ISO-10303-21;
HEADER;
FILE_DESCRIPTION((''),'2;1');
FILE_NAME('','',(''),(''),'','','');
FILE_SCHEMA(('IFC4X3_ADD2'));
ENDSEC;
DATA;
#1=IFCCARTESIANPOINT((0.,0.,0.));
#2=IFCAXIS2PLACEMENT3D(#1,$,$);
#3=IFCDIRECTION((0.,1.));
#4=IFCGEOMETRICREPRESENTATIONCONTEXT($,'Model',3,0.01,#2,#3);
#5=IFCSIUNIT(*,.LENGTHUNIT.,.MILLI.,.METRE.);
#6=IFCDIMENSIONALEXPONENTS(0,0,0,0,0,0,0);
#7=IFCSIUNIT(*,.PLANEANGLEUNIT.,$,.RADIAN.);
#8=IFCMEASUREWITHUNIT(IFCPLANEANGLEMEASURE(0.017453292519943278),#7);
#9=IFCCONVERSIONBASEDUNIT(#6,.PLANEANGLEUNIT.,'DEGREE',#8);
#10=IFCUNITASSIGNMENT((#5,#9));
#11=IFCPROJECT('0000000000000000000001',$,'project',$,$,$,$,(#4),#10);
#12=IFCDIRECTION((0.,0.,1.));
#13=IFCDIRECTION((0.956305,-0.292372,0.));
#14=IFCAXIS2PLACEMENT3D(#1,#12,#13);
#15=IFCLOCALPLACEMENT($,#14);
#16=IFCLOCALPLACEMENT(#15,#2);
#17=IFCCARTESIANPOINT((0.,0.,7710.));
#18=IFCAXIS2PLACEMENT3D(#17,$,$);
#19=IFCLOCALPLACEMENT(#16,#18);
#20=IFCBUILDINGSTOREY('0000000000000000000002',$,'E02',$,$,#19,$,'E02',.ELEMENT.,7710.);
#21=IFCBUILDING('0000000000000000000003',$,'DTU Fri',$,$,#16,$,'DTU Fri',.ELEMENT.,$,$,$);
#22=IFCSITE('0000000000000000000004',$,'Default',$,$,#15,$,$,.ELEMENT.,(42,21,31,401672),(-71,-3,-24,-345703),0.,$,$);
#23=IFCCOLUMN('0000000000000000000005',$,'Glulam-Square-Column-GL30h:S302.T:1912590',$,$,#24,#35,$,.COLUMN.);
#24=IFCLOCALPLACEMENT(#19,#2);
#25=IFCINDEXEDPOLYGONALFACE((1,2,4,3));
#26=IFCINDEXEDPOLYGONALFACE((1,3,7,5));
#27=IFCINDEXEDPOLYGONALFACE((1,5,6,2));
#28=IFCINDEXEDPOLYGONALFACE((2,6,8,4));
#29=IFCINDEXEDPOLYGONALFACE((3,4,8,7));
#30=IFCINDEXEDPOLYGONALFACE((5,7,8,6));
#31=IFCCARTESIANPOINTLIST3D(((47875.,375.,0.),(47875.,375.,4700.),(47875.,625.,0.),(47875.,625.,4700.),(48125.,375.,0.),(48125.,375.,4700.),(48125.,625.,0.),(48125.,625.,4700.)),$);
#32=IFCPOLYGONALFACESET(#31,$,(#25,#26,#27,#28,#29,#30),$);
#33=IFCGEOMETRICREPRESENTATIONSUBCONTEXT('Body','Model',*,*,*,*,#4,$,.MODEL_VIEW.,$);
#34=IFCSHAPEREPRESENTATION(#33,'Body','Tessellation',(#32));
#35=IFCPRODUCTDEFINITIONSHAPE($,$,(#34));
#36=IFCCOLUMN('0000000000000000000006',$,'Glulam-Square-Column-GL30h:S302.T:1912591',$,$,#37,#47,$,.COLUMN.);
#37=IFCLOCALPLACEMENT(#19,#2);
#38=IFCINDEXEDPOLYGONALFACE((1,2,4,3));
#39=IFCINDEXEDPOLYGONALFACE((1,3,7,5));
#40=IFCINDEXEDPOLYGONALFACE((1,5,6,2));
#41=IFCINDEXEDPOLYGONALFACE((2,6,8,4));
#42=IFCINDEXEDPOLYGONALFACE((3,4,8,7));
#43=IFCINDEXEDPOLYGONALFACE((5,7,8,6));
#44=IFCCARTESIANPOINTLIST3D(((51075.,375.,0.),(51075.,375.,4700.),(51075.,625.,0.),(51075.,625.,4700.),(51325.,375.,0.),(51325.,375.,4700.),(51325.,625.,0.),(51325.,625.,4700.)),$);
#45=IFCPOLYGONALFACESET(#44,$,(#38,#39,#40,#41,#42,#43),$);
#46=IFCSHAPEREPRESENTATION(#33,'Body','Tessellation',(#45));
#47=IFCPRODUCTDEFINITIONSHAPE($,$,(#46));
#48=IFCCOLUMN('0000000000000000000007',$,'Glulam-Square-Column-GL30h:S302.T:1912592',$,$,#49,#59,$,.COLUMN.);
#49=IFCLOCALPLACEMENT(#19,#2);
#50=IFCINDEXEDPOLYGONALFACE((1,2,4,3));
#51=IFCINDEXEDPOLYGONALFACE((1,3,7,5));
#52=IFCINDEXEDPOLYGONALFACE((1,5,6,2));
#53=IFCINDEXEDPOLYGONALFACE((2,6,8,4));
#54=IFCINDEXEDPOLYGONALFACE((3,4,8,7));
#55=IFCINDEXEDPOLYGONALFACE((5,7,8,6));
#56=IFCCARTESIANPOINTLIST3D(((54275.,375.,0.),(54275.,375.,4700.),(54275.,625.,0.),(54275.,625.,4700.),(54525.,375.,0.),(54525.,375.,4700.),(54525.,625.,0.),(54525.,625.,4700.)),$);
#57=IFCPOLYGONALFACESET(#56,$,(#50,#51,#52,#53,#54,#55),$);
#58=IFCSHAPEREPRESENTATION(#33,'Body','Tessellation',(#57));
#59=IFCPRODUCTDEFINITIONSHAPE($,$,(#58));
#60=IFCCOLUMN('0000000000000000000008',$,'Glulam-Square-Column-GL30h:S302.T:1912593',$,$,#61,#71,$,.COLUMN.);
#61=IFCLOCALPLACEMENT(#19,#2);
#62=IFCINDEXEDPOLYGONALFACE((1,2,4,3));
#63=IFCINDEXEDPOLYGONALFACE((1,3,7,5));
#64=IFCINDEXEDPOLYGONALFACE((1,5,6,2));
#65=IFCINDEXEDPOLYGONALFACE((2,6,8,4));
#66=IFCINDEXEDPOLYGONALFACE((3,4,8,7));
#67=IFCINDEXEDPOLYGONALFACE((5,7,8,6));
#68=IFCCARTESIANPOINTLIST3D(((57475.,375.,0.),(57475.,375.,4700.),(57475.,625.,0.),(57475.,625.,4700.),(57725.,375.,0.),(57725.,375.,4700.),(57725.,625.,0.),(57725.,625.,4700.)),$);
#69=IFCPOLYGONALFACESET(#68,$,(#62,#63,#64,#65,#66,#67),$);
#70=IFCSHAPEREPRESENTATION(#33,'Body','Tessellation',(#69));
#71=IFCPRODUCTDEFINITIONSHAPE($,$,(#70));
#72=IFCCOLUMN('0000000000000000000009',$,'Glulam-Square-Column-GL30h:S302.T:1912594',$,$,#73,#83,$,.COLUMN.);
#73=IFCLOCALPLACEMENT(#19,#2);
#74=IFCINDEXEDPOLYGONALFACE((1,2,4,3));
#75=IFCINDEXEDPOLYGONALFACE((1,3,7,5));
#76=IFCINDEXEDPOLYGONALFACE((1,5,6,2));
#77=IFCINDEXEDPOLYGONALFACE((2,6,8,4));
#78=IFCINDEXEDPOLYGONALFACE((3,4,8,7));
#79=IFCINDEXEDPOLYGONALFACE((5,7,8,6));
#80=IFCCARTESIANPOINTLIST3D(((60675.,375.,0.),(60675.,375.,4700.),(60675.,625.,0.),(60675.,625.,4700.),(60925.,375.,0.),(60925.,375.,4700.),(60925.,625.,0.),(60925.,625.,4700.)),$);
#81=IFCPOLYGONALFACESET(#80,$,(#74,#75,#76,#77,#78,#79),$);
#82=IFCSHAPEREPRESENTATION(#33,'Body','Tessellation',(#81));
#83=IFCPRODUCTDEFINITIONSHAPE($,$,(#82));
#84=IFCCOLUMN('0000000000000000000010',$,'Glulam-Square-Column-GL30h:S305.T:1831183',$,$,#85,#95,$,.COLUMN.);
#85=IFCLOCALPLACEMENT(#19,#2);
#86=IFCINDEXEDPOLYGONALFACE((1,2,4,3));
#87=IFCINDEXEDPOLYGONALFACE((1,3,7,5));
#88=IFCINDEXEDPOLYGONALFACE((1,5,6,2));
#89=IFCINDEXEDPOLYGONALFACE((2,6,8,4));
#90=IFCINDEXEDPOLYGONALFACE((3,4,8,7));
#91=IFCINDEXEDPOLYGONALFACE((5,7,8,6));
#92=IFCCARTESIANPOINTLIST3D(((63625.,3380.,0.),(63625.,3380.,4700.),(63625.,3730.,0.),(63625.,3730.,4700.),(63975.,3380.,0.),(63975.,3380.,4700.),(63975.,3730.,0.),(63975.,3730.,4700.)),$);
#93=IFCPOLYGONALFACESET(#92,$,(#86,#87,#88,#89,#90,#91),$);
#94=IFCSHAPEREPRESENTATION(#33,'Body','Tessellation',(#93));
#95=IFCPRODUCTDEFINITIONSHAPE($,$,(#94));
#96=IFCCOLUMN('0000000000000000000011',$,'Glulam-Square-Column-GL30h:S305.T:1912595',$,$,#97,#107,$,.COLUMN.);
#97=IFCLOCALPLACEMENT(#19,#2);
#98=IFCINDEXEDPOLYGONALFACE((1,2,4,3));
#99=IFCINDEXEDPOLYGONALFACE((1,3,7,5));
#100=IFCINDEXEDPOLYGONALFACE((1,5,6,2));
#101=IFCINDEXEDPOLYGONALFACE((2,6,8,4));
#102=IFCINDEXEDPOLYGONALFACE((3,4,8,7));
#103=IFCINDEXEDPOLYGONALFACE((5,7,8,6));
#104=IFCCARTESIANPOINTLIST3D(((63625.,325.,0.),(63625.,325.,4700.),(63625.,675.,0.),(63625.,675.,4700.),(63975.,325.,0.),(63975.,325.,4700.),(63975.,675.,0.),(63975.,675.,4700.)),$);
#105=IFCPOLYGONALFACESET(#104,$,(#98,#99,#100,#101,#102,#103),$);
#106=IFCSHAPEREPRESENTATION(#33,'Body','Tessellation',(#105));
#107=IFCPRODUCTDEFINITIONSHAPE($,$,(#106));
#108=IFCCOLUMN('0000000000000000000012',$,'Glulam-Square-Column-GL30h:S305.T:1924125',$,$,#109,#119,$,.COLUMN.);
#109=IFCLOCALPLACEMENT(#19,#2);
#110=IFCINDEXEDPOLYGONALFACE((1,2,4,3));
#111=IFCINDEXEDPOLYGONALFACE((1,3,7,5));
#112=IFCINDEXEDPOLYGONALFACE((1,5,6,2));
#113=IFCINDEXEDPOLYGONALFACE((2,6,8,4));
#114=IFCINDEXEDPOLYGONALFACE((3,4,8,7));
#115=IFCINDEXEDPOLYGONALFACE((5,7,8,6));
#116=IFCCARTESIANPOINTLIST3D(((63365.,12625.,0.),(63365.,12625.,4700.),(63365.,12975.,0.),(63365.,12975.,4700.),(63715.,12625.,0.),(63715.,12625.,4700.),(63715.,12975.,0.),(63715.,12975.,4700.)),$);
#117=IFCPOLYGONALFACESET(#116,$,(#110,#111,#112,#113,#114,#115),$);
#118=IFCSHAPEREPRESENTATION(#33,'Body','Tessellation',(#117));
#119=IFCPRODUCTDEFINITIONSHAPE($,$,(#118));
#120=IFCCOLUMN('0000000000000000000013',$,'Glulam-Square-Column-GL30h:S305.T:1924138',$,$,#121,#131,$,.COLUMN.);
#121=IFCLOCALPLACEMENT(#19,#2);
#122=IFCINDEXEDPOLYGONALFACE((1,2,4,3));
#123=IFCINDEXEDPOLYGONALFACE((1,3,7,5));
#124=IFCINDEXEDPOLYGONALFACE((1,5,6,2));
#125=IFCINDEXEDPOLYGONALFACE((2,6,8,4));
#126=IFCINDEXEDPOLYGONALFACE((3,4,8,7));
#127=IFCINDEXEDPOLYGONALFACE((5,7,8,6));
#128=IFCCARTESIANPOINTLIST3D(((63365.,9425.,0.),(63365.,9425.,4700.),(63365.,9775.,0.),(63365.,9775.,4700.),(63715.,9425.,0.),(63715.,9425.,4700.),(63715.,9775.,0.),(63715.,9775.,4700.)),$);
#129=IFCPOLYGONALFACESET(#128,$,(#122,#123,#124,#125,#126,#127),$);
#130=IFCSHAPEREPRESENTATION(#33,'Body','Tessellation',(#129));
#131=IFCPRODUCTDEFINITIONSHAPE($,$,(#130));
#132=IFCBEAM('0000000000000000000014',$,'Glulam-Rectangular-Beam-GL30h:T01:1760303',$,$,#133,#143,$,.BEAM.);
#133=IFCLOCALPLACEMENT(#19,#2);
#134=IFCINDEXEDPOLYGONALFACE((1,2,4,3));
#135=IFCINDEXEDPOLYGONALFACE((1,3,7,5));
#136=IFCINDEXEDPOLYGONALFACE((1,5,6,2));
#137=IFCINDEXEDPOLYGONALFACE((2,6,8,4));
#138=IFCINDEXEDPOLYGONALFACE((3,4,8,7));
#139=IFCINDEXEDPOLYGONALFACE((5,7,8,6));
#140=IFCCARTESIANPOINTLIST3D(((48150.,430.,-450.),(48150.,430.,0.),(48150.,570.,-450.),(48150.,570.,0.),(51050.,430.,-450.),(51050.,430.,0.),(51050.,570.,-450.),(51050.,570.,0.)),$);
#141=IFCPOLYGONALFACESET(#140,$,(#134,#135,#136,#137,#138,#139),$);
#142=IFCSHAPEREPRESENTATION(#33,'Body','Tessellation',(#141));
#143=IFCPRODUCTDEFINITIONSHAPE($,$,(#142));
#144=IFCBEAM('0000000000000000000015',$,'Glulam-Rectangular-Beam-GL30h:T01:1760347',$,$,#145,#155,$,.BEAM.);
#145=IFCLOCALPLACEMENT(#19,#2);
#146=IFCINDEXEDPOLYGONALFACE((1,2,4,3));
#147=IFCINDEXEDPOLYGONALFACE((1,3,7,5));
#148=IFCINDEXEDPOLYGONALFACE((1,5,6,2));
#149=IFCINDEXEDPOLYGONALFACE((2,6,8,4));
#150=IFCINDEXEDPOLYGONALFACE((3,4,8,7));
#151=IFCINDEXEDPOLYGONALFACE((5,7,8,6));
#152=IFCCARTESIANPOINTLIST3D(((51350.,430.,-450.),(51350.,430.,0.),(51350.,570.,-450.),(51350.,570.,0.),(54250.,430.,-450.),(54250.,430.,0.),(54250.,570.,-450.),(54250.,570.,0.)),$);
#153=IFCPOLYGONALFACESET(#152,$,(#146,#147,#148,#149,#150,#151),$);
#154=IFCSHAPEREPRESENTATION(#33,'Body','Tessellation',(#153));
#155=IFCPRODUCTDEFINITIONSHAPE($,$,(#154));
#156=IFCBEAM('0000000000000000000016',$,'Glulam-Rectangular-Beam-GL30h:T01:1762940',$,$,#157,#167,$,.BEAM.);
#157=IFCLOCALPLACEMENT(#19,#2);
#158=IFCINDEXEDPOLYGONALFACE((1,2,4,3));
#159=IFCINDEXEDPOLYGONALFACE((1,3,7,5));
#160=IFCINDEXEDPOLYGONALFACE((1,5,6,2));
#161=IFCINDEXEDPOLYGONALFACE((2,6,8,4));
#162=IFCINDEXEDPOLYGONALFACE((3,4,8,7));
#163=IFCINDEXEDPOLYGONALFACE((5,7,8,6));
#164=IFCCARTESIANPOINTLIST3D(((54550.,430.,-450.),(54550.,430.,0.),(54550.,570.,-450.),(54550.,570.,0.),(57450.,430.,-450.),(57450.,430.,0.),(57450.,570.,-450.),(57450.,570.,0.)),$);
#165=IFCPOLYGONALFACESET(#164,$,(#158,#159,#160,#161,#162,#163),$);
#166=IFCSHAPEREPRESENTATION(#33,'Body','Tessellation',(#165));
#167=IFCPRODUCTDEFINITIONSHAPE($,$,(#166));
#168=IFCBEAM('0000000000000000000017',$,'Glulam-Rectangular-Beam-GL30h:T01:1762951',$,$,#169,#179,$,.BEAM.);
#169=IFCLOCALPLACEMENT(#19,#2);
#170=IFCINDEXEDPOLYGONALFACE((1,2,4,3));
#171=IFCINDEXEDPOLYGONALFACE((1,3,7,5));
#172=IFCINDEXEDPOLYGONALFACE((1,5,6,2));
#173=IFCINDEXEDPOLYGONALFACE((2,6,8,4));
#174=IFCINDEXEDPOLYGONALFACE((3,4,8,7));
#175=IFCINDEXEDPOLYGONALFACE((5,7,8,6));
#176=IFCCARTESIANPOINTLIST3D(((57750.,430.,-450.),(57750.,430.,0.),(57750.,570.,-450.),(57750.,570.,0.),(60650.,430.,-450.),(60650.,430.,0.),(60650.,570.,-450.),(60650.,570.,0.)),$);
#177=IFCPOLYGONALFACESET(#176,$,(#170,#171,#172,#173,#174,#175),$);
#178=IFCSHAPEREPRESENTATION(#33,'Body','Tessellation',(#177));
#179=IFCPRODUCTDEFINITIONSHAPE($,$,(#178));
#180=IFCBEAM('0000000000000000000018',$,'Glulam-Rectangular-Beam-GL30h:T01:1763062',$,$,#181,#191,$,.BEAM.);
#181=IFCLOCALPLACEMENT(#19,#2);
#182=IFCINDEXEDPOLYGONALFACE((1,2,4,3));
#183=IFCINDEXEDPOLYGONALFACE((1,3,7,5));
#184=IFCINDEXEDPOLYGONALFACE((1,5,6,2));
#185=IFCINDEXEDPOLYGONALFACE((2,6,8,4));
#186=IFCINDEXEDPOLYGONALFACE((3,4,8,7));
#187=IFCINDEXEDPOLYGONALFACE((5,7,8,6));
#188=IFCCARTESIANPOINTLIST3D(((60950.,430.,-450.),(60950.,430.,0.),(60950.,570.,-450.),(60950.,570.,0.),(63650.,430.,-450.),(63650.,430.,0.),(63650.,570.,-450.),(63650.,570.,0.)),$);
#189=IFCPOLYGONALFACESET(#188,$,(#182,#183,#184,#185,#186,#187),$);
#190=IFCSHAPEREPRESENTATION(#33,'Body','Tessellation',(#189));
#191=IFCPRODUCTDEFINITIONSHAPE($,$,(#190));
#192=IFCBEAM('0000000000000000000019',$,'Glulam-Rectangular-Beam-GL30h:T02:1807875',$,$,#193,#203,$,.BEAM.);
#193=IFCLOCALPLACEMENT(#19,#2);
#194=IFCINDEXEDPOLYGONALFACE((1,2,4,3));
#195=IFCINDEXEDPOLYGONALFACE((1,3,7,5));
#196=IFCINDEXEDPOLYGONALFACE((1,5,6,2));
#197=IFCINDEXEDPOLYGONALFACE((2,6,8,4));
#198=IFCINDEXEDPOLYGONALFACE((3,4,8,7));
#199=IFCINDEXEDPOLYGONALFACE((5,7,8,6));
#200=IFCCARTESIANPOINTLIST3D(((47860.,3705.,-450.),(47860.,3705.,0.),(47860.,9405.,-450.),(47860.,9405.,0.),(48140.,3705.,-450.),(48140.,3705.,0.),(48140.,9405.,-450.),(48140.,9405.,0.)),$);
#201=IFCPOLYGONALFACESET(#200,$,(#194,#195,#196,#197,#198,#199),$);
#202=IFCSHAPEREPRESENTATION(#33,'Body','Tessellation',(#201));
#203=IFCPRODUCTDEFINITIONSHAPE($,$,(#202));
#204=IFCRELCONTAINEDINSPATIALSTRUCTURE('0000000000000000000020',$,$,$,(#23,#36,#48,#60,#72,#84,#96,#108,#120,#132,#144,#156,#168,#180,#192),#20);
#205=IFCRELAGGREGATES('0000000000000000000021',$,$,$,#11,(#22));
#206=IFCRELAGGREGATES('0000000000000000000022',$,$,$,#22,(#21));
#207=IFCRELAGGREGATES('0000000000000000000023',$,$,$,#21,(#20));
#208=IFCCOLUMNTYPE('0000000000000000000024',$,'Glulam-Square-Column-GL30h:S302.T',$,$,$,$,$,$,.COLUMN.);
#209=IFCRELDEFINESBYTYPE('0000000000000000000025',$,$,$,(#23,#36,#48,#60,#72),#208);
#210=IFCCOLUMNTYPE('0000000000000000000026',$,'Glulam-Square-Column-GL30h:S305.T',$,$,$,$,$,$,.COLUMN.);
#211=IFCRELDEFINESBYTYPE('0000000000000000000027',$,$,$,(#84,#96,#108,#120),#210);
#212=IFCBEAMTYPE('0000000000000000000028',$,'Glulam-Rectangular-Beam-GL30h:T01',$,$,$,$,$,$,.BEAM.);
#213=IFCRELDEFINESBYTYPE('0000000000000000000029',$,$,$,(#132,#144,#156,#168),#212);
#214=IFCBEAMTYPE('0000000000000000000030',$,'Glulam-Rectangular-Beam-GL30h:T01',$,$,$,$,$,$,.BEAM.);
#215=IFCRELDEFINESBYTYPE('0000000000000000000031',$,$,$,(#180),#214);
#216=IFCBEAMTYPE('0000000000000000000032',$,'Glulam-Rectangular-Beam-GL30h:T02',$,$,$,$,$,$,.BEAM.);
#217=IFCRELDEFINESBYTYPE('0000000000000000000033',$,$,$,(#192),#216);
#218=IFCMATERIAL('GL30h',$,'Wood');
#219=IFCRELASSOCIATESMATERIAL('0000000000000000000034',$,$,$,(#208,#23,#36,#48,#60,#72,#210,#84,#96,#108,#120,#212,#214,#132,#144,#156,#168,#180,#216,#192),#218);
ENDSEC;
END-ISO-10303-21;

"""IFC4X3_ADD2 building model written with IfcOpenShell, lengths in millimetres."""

from ifc_helpers import new_model, entity, si_unit, converted_unit, direction, frame, origin, origin_2d_with_axis, place, context, subcontext, project, spatial, rectangle, extrude, source, transform, mapped, material, material_profile, profile_set, profile_usage, type_object, type_shapes, element, save


model = new_model("IFC4X3_ADD2")

# Units and contexts
model_context = context("Model", 3, precision=0.01, world=origin(), true_north=direction((0.0, 1.0)))
body_context = subcontext(model_context, "Body", "Model", "MODEL_VIEW")
ifc_project = project(units=[si_unit("LENGTHUNIT", "METRE", prefix="MILLI"), converted_unit("PLANEANGLEUNIT", "DEGREE", entity("IfcPlaneAngleMeasure", 0.017453292519943278), si_unit("PLANEANGLEUNIT", "RADIAN"), dimensions=[0, 0, 0, 0, 0, 0, 0])], contexts=[model_context])

# Site, building, storey
site_placement = place(None, frame((0.0, 0.0, 0.0), z_axis=(0.0, 0.0, 1.0), x_axis=(0.956305, -0.292372, 0.0)))
site = spatial("IfcSite", under=ifc_project, at=site_placement, Name="Default", CompositionType="ELEMENT", RefLatitude=(42, 21, 31, 401672), RefLongitude=(-71, -3, -24, -345703), RefElevation=0.0)
building_placement = place(site_placement, origin())
building = spatial("IfcBuilding", under=site, at=building_placement, Name="DTU Fri", LongName="DTU Fri", CompositionType="ELEMENT")
storey_placement = place(building_placement, frame((0.0, 0.0, 7710.0)))
storey = spatial("IfcBuildingStorey", under=building, at=storey_placement, Name="E02", LongName="E02", CompositionType="ELEMENT", Elevation=7710.0)

# Columns
ifc_material_1 = material(Name="GL30h", Category="Wood")
ifc_material_profile_1 = material_profile(ifc_material_1, rectangle(XDim=250.0, YDim=250.0, at=origin_2d_with_axis()), Name="S302.T")
ifc_profile_set_1 = profile_set([ifc_material_profile_1], Name="S302.T")
ifc_profile_usage_1 = profile_usage(ifc_profile_set_1)
column_type_1 = type_object("IfcColumnType", Name="Glulam-Square-Column-GL30h:S302.T", PredefinedType="COLUMN", material=ifc_profile_set_1)
shared_shape_1 = source(origin(), body_context, "Body", "SweptSolid", [
    extrude(rectangle(XDim=250.0, YDim=250.0, at=origin_2d_with_axis()), frame((0.0, 0.0, 7710.0), z_axis=(0.0, 0.0, 1.0), x_axis=(0.0, 1.0, 0.0)), (0.0, 0.0, 1.0), 4700.0),
])
type_shapes(column_type_1, [shared_shape_1])
for number, where, name in (
    (1, (48000.0, 500.0, -7710.0), "Glulam-Square-Column-GL30h:S302.T:1912590"),
    (2, (51200.0, 500.0, -7710.0), "Glulam-Square-Column-GL30h:S302.T:1912591"),
    (3, (54400.0, 500.0, -7710.0), "Glulam-Square-Column-GL30h:S302.T:1912592"),
    (4, (57600.0, 500.0, -7710.0), "Glulam-Square-Column-GL30h:S302.T:1912593"),
    (5, (60800.0, 500.0, -7710.0), "Glulam-Square-Column-GL30h:S302.T:1912594"),
):
    element("IfcColumn", number, at=place(storey_placement, frame(where)), inside=storey, type_object=column_type_1, material=ifc_profile_usage_1, Name=name, PredefinedType="COLUMN", context=body_context, shape_type="MappedRepresentation", body=[
        mapped(shared_shape_1, transform((0.0, 0.0, 0.0), scale=1.0)),
    ])
ifc_material_profile_2 = material_profile(ifc_material_1, rectangle(XDim=350.0, YDim=350.0, at=origin_2d_with_axis()), Name="S305.T")
ifc_profile_set_2 = profile_set([ifc_material_profile_2], Name="S305.T")
ifc_profile_usage_2 = profile_usage(ifc_profile_set_2)
column_type_2 = type_object("IfcColumnType", Name="Glulam-Square-Column-GL30h:S305.T", PredefinedType="COLUMN", material=ifc_profile_set_2)
shared_shape_2 = source(origin(), body_context, "Body", "SweptSolid", [
    extrude(rectangle(XDim=350.0, YDim=350.0, at=origin_2d_with_axis()), frame((0.0, 0.0, 7710.0), z_axis=(0.0, 0.0, 1.0), x_axis=(0.0, 1.0, 0.0)), (0.0, 0.0, 1.0), 4700.0),
])
type_shapes(column_type_2, [shared_shape_2])
for number, where, name in (
    (6, (63800.0, 3555.0, -7710.0), "Glulam-Square-Column-GL30h:S305.T:1831183"),
    (7, (63800.0, 500.0, -7710.0), "Glulam-Square-Column-GL30h:S305.T:1912595"),
    (8, (63540.0, 12800.0, -7710.0), "Glulam-Square-Column-GL30h:S305.T:1924125"),
    (9, (63540.0, 9600.0, -7710.0), "Glulam-Square-Column-GL30h:S305.T:1924138"),
):
    element("IfcColumn", number, at=place(storey_placement, frame(where)), inside=storey, type_object=column_type_2, material=ifc_profile_usage_2, Name=name, PredefinedType="COLUMN", context=body_context, shape_type="MappedRepresentation", body=[
        mapped(shared_shape_2, transform((0.0, 0.0, 0.0), scale=1.0)),
    ])

# Beams
ifc_material_profile_3 = material_profile(ifc_material_1, rectangle(XDim=450.0, YDim=140.0, at=origin_2d_with_axis()), Name="T01")
ifc_profile_set_3 = profile_set([ifc_material_profile_3], Name="T01")
ifc_profile_usage_3 = profile_usage(ifc_profile_set_3, cardinal=8)
beam_type_1 = type_object("IfcBeamType", Name="Glulam-Rectangular-Beam-GL30h:T01", PredefinedType="BEAM", material=ifc_profile_set_3)
shared_shape_3 = source(origin(), body_context, "Body", "SweptSolid", [
    extrude(rectangle(XDim=450.0, YDim=140.0, at=origin_2d_with_axis()), frame((-1450.0, 0.0, 0.0), z_axis=(1.0, 0.0, 0.0), x_axis=(0.0, 0.0, -1.0)), (0.0, 0.0, 1.0), 2900.0),
])
type_shapes(beam_type_1, [shared_shape_3])
for number, where, name in (
    (10, (49600.0, 500.0, -225.0), "Glulam-Rectangular-Beam-GL30h:T01:1760303"),
    (11, (52800.0, 500.0, -225.0), "Glulam-Rectangular-Beam-GL30h:T01:1760347"),
    (12, (56000.0, 500.0, -225.0), "Glulam-Rectangular-Beam-GL30h:T01:1762940"),
    (13, (59200.0, 500.0, -225.0), "Glulam-Rectangular-Beam-GL30h:T01:1762951"),
):
    element("IfcBeam", number, at=place(storey_placement, frame(where)), inside=storey, type_object=beam_type_1, material=ifc_profile_usage_3, Name=name, PredefinedType="BEAM", context=body_context, shape_type="MappedRepresentation", body=[
        mapped(shared_shape_3, transform((0.0, 0.0, 0.0), scale=1.0)),
    ])
beam_type_2 = type_object("IfcBeamType", Name="Glulam-Rectangular-Beam-GL30h:T01", PredefinedType="BEAM", material=ifc_profile_set_3)
shared_shape_4 = source(origin(), body_context, "Body", "SweptSolid", [
    extrude(rectangle(XDim=450.0, YDim=140.0, at=origin_2d_with_axis()), frame((-1350.0, 0.0, 0.0), z_axis=(1.0, 0.0, 0.0), x_axis=(0.0, 0.0, -1.0)), (0.0, 0.0, 1.0), 2700.0),
])
type_shapes(beam_type_2, [shared_shape_4])
beam_1_placement = place(storey_placement, frame((62300.0, 500.0, -225.0)))
element("IfcBeam", 14, at=beam_1_placement, inside=storey, type_object=beam_type_2, material=ifc_profile_usage_3, Name="Glulam-Rectangular-Beam-GL30h:T01:1763062", PredefinedType="BEAM", context=body_context, shape_type="MappedRepresentation", body=[
    mapped(shared_shape_4, transform((0.0, 0.0, 0.0), scale=1.0)),
])
ifc_material_profile_4 = material_profile(ifc_material_1, rectangle(XDim=450.0, YDim=280.0, at=origin_2d_with_axis()), Name="T02")
ifc_profile_set_4 = profile_set([ifc_material_profile_4], Name="T02")
ifc_profile_usage_4 = profile_usage(ifc_profile_set_4, cardinal=8)
beam_type_3 = type_object("IfcBeamType", Name="Glulam-Rectangular-Beam-GL30h:T02", PredefinedType="BEAM", material=ifc_profile_set_4)
shared_shape_5 = source(origin(), body_context, "Body", "SweptSolid", [
    extrude(rectangle(XDim=450.0, YDim=280.0, at=origin_2d_with_axis()), frame((-2872.5, 0.0, 0.0), z_axis=(1.0, 0.0, 0.0), x_axis=(0.0, 0.0, -1.0)), (0.0, 0.0, 1.0), 5700.0),
])
type_shapes(beam_type_3, [shared_shape_5])
beam_2_placement = place(storey_placement, frame((48000.0, 6577.5, -225.0), z_axis=(0.0, 0.0, 1.0), x_axis=(0.0, 1.0, 0.0)))
element("IfcBeam", 15, at=beam_2_placement, inside=storey, type_object=beam_type_3, material=ifc_profile_usage_4, Name="Glulam-Rectangular-Beam-GL30h:T02:1807875", PredefinedType="BEAM", context=body_context, shape_type="MappedRepresentation", body=[
    mapped(shared_shape_5, transform((0.0, 0.0, 0.0), scale=1.0)),
])

save(model, "model.ifc")
